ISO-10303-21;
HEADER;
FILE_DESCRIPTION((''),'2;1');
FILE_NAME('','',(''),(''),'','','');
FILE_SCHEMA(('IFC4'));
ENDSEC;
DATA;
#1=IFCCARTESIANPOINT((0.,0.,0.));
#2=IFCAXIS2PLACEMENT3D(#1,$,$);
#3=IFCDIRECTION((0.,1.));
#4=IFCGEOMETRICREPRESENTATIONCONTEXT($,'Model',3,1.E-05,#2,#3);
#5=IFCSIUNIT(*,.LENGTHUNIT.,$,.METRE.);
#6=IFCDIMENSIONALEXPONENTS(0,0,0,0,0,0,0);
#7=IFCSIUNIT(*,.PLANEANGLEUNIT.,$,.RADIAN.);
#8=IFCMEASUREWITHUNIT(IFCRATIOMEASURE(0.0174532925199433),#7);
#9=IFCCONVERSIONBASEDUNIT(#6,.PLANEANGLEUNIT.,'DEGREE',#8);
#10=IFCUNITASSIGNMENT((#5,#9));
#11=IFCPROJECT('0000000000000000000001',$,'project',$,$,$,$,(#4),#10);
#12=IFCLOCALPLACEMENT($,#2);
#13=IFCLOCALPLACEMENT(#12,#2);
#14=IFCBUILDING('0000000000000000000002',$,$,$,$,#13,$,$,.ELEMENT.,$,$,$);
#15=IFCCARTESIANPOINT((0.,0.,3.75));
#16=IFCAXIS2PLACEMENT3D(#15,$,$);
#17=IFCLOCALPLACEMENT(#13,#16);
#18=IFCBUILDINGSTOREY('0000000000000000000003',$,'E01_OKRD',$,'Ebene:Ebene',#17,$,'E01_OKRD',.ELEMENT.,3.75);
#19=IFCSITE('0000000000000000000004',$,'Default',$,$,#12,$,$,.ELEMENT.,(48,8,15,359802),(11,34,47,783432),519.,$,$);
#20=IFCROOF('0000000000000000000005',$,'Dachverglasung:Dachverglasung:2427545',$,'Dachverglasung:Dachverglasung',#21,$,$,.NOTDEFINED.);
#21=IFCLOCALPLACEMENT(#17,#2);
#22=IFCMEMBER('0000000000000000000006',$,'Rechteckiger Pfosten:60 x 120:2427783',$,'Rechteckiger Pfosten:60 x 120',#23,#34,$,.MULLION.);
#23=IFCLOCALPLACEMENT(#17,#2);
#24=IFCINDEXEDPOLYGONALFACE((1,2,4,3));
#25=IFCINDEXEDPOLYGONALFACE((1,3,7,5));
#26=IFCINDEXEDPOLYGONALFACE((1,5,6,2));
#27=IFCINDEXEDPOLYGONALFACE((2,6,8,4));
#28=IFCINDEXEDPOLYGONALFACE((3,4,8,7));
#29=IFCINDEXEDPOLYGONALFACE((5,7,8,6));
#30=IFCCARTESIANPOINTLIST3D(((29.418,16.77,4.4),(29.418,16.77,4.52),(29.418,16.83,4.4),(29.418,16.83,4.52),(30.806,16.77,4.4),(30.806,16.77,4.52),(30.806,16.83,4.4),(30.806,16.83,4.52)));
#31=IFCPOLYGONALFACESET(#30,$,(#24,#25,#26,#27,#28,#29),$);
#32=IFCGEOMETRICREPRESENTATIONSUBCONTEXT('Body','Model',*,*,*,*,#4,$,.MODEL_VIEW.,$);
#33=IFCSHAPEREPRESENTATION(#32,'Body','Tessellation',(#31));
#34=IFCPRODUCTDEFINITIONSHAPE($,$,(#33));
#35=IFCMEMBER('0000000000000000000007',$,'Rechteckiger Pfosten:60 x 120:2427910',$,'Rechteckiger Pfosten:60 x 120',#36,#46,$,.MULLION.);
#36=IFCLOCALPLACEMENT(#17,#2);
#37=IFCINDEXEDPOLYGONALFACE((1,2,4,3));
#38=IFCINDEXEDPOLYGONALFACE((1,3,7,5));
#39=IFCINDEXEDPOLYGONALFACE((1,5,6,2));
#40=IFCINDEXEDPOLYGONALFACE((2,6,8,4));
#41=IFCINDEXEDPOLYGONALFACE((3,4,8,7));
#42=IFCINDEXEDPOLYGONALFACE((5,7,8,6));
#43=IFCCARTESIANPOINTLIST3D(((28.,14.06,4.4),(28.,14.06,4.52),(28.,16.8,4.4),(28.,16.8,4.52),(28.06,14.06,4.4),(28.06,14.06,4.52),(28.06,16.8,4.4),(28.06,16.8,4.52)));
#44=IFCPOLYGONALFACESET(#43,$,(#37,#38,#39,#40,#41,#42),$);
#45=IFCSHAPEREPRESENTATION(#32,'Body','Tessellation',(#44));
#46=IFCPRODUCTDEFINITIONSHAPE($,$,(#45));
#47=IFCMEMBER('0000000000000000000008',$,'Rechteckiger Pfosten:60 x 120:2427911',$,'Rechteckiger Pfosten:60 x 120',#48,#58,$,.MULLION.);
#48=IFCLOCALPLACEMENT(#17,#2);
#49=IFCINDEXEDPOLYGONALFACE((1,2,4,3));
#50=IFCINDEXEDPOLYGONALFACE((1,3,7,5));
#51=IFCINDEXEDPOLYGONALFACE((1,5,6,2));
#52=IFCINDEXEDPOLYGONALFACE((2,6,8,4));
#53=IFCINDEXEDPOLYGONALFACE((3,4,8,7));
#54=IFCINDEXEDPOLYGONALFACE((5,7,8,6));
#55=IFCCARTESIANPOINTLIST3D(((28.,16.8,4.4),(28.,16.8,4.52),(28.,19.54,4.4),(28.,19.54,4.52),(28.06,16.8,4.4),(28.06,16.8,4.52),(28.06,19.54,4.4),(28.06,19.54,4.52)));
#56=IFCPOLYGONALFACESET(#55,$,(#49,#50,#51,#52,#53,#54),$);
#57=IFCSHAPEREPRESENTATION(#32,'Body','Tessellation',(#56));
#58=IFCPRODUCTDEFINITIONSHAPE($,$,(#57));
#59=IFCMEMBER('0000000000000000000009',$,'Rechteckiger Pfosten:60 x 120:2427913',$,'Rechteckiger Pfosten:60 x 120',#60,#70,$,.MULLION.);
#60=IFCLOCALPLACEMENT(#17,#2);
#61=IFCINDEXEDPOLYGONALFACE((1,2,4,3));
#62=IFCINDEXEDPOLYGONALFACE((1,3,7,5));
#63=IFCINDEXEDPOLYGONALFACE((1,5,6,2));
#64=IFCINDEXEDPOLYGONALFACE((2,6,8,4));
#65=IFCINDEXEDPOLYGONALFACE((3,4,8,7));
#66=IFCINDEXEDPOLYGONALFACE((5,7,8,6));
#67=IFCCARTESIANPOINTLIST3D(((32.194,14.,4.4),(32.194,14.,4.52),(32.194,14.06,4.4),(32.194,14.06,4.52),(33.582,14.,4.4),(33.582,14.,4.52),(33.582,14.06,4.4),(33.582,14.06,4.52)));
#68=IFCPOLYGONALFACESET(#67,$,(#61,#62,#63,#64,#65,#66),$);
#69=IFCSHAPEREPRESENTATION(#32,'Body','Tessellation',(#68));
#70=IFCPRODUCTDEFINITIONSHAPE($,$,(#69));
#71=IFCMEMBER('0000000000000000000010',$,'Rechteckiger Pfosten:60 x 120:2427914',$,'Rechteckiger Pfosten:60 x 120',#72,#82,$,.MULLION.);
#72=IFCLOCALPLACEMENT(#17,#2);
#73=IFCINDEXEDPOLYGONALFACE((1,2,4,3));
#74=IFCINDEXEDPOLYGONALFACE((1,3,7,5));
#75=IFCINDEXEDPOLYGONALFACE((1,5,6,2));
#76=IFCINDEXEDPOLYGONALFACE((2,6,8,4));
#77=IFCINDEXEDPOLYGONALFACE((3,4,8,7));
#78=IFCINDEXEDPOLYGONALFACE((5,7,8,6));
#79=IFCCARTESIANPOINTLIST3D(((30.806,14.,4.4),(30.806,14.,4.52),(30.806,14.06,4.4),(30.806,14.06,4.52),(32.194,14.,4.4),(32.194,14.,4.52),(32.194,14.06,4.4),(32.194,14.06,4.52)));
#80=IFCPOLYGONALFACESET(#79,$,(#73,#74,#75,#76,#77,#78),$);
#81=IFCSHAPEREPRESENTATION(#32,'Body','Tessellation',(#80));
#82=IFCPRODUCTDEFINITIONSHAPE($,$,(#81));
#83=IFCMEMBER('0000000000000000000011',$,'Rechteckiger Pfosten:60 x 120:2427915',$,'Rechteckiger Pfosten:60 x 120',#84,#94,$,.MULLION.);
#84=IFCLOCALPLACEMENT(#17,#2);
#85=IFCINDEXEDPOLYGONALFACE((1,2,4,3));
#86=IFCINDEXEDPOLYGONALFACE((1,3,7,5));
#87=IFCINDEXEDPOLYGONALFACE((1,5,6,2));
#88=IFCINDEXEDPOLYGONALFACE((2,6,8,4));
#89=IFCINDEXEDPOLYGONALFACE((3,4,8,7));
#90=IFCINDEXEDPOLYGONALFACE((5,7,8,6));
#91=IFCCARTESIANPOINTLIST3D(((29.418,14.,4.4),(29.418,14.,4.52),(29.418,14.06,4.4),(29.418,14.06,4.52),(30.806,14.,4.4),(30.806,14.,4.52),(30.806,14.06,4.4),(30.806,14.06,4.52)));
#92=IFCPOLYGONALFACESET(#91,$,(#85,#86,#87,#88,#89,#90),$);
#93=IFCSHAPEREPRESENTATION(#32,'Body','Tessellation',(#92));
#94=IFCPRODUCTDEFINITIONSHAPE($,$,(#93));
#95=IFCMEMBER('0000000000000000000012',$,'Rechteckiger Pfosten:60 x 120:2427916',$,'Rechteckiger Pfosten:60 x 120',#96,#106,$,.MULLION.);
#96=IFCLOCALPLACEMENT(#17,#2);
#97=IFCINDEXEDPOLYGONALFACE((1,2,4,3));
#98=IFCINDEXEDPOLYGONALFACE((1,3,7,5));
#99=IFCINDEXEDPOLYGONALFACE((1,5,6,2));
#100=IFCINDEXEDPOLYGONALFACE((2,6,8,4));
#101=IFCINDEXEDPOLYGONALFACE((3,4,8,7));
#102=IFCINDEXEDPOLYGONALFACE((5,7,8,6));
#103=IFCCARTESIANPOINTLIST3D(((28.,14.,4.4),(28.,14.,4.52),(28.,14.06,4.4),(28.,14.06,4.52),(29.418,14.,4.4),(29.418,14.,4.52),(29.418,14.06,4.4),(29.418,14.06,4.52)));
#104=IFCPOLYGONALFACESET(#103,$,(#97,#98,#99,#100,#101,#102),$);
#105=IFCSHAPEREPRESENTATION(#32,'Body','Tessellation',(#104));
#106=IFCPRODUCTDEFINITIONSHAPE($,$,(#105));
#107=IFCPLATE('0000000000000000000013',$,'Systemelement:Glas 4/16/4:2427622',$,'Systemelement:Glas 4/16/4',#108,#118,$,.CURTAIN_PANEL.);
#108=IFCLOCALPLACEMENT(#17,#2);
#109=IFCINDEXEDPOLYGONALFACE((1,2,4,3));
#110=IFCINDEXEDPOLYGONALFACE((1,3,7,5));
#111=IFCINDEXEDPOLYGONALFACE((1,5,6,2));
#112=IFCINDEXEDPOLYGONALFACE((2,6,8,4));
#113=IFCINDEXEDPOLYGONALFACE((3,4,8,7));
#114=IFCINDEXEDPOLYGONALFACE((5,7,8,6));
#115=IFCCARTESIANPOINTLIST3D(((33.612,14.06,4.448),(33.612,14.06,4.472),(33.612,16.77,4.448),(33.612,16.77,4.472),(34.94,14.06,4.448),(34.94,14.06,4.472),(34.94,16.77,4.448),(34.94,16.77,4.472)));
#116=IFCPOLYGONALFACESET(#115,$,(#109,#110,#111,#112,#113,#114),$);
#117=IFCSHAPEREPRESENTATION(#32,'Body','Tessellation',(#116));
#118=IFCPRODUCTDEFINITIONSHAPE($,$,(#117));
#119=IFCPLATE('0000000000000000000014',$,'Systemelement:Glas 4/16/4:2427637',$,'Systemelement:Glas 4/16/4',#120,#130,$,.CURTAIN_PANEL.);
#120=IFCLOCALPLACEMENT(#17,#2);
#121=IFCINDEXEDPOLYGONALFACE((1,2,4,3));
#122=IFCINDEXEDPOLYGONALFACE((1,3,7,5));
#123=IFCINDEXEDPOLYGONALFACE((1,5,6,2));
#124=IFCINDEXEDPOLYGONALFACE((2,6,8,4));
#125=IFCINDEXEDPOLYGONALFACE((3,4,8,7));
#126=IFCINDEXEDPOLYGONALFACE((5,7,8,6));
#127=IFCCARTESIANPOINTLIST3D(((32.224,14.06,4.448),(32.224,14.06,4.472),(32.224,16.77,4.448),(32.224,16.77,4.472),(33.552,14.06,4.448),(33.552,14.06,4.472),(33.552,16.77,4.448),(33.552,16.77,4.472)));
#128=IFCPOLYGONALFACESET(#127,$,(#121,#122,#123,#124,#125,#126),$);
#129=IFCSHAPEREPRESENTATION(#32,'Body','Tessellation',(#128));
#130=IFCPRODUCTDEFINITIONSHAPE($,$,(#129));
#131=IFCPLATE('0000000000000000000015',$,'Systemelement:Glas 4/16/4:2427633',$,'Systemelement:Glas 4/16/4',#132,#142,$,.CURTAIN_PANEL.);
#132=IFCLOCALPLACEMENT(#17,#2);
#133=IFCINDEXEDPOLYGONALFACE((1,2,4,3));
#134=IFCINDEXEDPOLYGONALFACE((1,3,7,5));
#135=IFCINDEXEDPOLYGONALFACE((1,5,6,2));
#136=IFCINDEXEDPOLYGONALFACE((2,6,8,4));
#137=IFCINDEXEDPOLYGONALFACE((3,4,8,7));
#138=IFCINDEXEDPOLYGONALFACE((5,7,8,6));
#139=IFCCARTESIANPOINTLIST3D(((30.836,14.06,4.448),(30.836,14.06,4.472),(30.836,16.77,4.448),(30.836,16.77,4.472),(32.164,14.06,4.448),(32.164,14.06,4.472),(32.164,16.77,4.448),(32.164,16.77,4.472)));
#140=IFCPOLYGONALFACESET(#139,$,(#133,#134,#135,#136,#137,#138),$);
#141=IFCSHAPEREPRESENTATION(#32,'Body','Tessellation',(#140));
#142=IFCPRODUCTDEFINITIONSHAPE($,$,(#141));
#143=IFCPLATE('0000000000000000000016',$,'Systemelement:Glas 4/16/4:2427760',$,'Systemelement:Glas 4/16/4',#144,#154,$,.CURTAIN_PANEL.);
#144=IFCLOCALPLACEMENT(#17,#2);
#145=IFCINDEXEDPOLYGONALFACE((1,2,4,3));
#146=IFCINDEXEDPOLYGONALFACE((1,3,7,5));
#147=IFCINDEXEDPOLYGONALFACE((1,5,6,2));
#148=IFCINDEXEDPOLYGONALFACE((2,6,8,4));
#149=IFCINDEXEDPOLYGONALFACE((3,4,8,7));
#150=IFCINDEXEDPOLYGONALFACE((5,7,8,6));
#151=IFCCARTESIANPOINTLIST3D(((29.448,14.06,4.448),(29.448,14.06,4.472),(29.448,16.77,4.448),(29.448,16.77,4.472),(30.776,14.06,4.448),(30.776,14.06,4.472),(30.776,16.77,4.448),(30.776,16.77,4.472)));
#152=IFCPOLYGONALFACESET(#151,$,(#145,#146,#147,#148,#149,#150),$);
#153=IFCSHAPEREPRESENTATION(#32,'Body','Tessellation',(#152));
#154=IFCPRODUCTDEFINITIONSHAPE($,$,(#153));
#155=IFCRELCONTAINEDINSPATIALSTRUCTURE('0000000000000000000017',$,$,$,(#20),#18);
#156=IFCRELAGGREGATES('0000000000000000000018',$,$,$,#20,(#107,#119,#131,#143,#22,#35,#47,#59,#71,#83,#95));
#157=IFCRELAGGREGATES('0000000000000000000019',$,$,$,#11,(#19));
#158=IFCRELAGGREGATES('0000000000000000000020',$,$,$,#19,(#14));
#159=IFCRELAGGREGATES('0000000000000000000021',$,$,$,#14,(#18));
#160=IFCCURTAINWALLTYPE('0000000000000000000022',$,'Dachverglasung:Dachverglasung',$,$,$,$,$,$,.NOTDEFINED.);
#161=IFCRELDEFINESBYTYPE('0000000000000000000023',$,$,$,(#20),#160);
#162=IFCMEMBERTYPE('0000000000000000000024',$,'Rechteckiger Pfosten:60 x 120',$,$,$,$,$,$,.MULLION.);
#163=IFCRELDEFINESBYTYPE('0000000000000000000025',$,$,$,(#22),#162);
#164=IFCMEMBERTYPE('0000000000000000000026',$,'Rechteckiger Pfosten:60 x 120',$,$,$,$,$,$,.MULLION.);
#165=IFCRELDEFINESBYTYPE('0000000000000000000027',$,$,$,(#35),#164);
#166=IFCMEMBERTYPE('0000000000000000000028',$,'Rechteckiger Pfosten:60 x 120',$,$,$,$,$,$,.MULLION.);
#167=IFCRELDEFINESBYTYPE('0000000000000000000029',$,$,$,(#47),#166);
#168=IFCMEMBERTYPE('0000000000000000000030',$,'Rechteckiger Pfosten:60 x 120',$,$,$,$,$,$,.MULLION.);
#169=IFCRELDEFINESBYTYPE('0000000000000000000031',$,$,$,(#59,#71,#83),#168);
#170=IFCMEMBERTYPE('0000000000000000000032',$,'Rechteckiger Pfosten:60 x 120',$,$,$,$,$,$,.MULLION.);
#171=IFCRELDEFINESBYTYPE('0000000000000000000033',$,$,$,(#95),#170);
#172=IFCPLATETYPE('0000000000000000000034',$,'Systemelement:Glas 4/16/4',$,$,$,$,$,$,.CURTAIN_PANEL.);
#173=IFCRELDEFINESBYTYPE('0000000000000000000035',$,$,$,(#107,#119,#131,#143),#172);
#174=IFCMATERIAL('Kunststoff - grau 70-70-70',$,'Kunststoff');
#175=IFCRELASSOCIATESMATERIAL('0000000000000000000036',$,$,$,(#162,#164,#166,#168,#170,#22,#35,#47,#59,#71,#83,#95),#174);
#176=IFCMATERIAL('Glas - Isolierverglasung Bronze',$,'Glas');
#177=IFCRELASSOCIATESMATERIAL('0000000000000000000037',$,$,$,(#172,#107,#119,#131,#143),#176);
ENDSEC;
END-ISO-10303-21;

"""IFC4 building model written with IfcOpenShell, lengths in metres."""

from ifc_helpers import new_model, entity, si_unit, converted_unit, direction, frame, frame_2d, origin, origin_2d_with_axis, place, context, subcontext, project, spatial, rectangle, extrude, shape, source, transform, mapped, material, material_profile, profile_set, profile_usage, type_object, type_shapes, element, aggregate, save


model = new_model("IFC4")

# Units and contexts
model_context = context("Model", 3, precision=1e-05, world=origin(), true_north=direction((0.0, 1.0)))
body_context = subcontext(model_context, "Body", "Model", "MODEL_VIEW")
footprint_context = subcontext(model_context, "FootPrint", "Model", "MODEL_VIEW")
ifc_project = project(units=[si_unit("LENGTHUNIT", "METRE"), converted_unit("PLANEANGLEUNIT", "DEGREE", entity("IfcRatioMeasure", 0.0174532925199433), si_unit("PLANEANGLEUNIT", "RADIAN"), dimensions=[0, 0, 0, 0, 0, 0, 0])], contexts=[model_context])

# Site, building, storey
site_placement = place(None, frame((0.0, 0.0, 0.0)))
site = spatial("IfcSite", under=ifc_project, at=site_placement, Name="Default", CompositionType="ELEMENT", RefLatitude=(48, 8, 15, 359802), RefLongitude=(11, 34, 47, 783432), RefElevation=519.0)
building_placement = place(site_placement, origin())
building = spatial("IfcBuilding", under=site, at=building_placement, CompositionType="ELEMENT")
storey_placement = place(building_placement, frame((0.0, 0.0, 3.75)))
storey = spatial("IfcBuildingStorey", under=building, at=storey_placement, Name="E01_OKRD", ObjectType="Ebene:Ebene", LongName="E01_OKRD", CompositionType="ELEMENT", Elevation=3.75)

# Roof, members, plates
curtain_wall_type = type_object("IfcCurtainWallType", Name="Dachverglasung:Dachverglasung", PredefinedType="NOTDEFINED")
roof_placement = place(storey_placement, frame((0.0, 0.0, -3.75)))
roof = element("IfcRoof", 1, at=roof_placement, inside=storey, type_object=curtain_wall_type, Name="Dachverglasung:Dachverglasung:2427545", ObjectType="Dachverglasung:Dachverglasung", PredefinedType="NOTDEFINED")
ifc_material_1 = material(Name="Kunststoff - grau 70-70-70", Category="Kunststoff")
ifc_material_profile_1 = material_profile(ifc_material_1, rectangle(XDim=0.06, YDim=0.12, at=frame_2d((0.0, 0.0), x_axis=(1.0, 0.0))), Name="60 x 120")
ifc_profile_set_1 = profile_set([ifc_material_profile_1], Name="60 x 120")
ifc_profile_usage_1 = profile_usage(ifc_profile_set_1)
member_type_1 = type_object("IfcMemberType", Name="Rechteckiger Pfosten:60 x 120", PredefinedType="MULLION", material=ifc_profile_set_1)
shared_shape_1 = source(origin(), body_context, "Body", "SweptSolid", [
    extrude(rectangle(XDim=0.06, YDim=0.12, at=frame_2d((0.0, 0.0), x_axis=(1.0, 0.0))), frame((0.0, 0.0, -1.388), z_axis=(0.0, 0.0, 1.0), x_axis=(-1.0, 0.0, 0.0)), (0.0, 0.0, 1.0), 1.388),
])
type_shapes(member_type_1, [shared_shape_1])
member_1_placement = place(storey_placement, frame((29.418, 16.8, 4.46), z_axis=(-1.0, 0.0, 0.0), x_axis=(0.0, 1.0, 0.0)))
member_1 = element("IfcMember", 2, at=member_1_placement, type_object=member_type_1, material=ifc_profile_usage_1, Name="Rechteckiger Pfosten:60 x 120:2427783", ObjectType="Rechteckiger Pfosten:60 x 120", PredefinedType="MULLION", context=body_context, shape_type="MappedRepresentation", body=[
    mapped(shared_shape_1, transform((0.0, 0.0, 0.0), scale=1.0)),
])
ifc_profile_usage_2 = profile_usage(ifc_profile_set_1)
member_type_2 = type_object("IfcMemberType", Name="Rechteckiger Pfosten:60 x 120", PredefinedType="MULLION", material=ifc_profile_set_1)
shared_shape_2 = source(origin(), body_context, "Body", "SweptSolid", [
    extrude(rectangle(XDim=0.06, YDim=0.12, at=origin_2d_with_axis()), frame((-0.03, 0.0, -2.74), z_axis=(0.0, 0.0, 1.0), x_axis=(-1.0, 0.0, 0.0)), (0.0, 0.0, 1.0), 2.74),
])
type_shapes(member_type_2, [shared_shape_2])
member_2_placement = place(storey_placement, frame((28.0, 14.06, 4.46), z_axis=(0.0, -1.0, 0.0), x_axis=(-1.0, 0.0, 0.0)))
member_2 = element("IfcMember", 3, at=member_2_placement, type_object=member_type_2, material=ifc_profile_usage_2, Name="Rechteckiger Pfosten:60 x 120:2427910", ObjectType="Rechteckiger Pfosten:60 x 120", PredefinedType="MULLION", context=body_context, shape_type="MappedRepresentation", body=[
    mapped(shared_shape_2, transform((0.0, 0.0, 0.0), scale=1.0)),
])
ifc_profile_usage_3 = profile_usage(ifc_profile_set_1)
member_type_3 = type_object("IfcMemberType", Name="Rechteckiger Pfosten:60 x 120", PredefinedType="MULLION", material=ifc_profile_set_1)
shared_shape_3 = source(origin(), body_context, "Body", "SweptSolid", [
    extrude(rectangle(XDim=0.06, YDim=0.12, at=origin_2d_with_axis()), frame((-0.03, 0.0, -2.74), z_axis=(0.0, 0.0, 1.0), x_axis=(-1.0, 0.0, 0.0)), (0.0, 0.0, 1.0), 2.74),
])
type_shapes(member_type_3, [shared_shape_3])
member_3_placement = place(storey_placement, frame((28.0, 16.8, 4.46), z_axis=(0.0, -1.0, 0.0), x_axis=(-1.0, 0.0, 0.0)))
member_3 = element("IfcMember", 4, at=member_3_placement, type_object=member_type_3, material=ifc_profile_usage_3, Name="Rechteckiger Pfosten:60 x 120:2427911", ObjectType="Rechteckiger Pfosten:60 x 120", PredefinedType="MULLION", context=body_context, shape_type="MappedRepresentation", body=[
    mapped(shared_shape_3, transform((0.0, 0.0, 0.0), scale=1.0)),
])
ifc_profile_usage_4 = profile_usage(ifc_profile_set_1)
member_type_4 = type_object("IfcMemberType", Name="Rechteckiger Pfosten:60 x 120", PredefinedType="MULLION", material=ifc_profile_set_1)
shared_shape_4 = source(origin(), body_context, "Body", "SweptSolid", [
    extrude(rectangle(XDim=0.06, YDim=0.12, at=origin_2d_with_axis()), frame((-0.03, 0.0, -1.388), z_axis=(0.0, 0.0, 1.0), x_axis=(-1.0, 0.0, 0.0)), (0.0, 0.0, 1.0), 1.388),
])
type_shapes(member_type_4, [shared_shape_4])
member_4_placement = place(storey_placement, frame((33.582, 14.0, 4.46), z_axis=(1.0, 0.0, 0.0), x_axis=(0.0, -1.0, 0.0)))
member_4 = element("IfcMember", 5, at=member_4_placement, type_object=member_type_4, material=ifc_profile_usage_4, Name="Rechteckiger Pfosten:60 x 120:2427913", ObjectType="Rechteckiger Pfosten:60 x 120", PredefinedType="MULLION", context=body_context, shape_type="MappedRepresentation", body=[
    mapped(shared_shape_4, transform((0.0, 0.0, 0.0), scale=1.0)),
])
ifc_profile_usage_5 = profile_usage(ifc_profile_set_1)
member_5_placement = place(storey_placement, frame((32.194, 14.0, 4.46), z_axis=(1.0, 0.0, 0.0), x_axis=(0.0, -1.0, 0.0)))
member_5 = element("IfcMember", 6, at=member_5_placement, type_object=member_type_4, material=ifc_profile_usage_5, Name="Rechteckiger Pfosten:60 x 120:2427914", ObjectType="Rechteckiger Pfosten:60 x 120", PredefinedType="MULLION", context=body_context, shape_type="MappedRepresentation", body=[
    mapped(shared_shape_4, transform((0.0, 0.0, 0.0), scale=1.0)),
])
ifc_profile_usage_6 = profile_usage(ifc_profile_set_1)
member_6_placement = place(storey_placement, frame((30.806, 14.0, 4.46), z_axis=(1.0, 0.0, 0.0), x_axis=(0.0, -1.0, 0.0)))
member_6 = element("IfcMember", 7, at=member_6_placement, type_object=member_type_4, material=ifc_profile_usage_6, Name="Rechteckiger Pfosten:60 x 120:2427915", ObjectType="Rechteckiger Pfosten:60 x 120", PredefinedType="MULLION", context=body_context, shape_type="MappedRepresentation", body=[
    mapped(shared_shape_4, transform((0.0, 0.0, 0.0), scale=1.0)),
])
ifc_profile_usage_7 = profile_usage(ifc_profile_set_1)
member_type_5 = type_object("IfcMemberType", Name="Rechteckiger Pfosten:60 x 120", PredefinedType="MULLION", material=ifc_profile_set_1)
shared_shape_5 = source(origin(), body_context, "Body", "SweptSolid", [
    extrude(rectangle(XDim=0.06, YDim=0.12, at=origin_2d_with_axis()), frame((-0.03, 0.0, -1.418), z_axis=(0.0, 0.0, 1.0), x_axis=(-1.0, 0.0, 0.0)), (0.0, 0.0, 1.0), 1.418),
])
type_shapes(member_type_5, [shared_shape_5])
member_7_placement = place(storey_placement, frame((29.418, 14.0, 4.46), z_axis=(1.0, 0.0, 0.0), x_axis=(0.0, -1.0, 0.0)))
member_7 = element("IfcMember", 8, at=member_7_placement, type_object=member_type_5, material=ifc_profile_usage_7, Name="Rechteckiger Pfosten:60 x 120:2427916", ObjectType="Rechteckiger Pfosten:60 x 120", PredefinedType="MULLION", context=body_context, shape_type="MappedRepresentation", body=[
    mapped(shared_shape_5, transform((0.0, 0.0, 0.0), scale=1.0)),
])
ifc_material_2 = material(Name="Glas - Isolierverglasung Bronze", Category="Glas")
plate_type = type_object("IfcPlateType", Name="Systemelement:Glas 4/16/4", PredefinedType="CURTAIN_PANEL", material=ifc_material_2)
shared_shape_6 = source(origin(), body_context, "Body", "SweptSolid", [
    extrude(rectangle(XDim=0.024, YDim=2.71, at=origin_2d_with_axis()), frame((0.0, 0.0, 0.0), z_axis=(0.0, 0.0, 1.0), x_axis=(0.0, 1.0, 0.0)), (0.0, 0.0, 1.0), 1.328),
])
cartesian_point = entity("IfcCartesianPoint", [1.355, -0.012])
shared_shape_7 = source(origin(), footprint_context, "FootPrint", "Curve2D", [
    entity("IfcPolyline", [cartesian_point, entity("IfcCartesianPoint", [1.355, 0.012]), entity("IfcCartesianPoint", [-1.355, 0.012]), entity("IfcCartesianPoint", [-1.355, -0.012]), cartesian_point]),
])
type_shapes(plate_type, [shared_shape_6, shared_shape_7])
plate_1_placement = place(roof_placement, frame((34.94, 15.415, 8.21), z_axis=(-1.0, 0.0, 0.0), x_axis=(0.0, 1.0, 0.0)))
plate_1 = element("IfcPlate", 9, at=plate_1_placement, type_object=plate_type, material=ifc_material_2, Name="Systemelement:Glas 4/16/4:2427622", ObjectType="Systemelement:Glas 4/16/4", PredefinedType="CURTAIN_PANEL", shapes=[
    shape(body_context, "Body", "MappedRepresentation", [mapped(shared_shape_6, transform((0.0, 0.0, 0.0), scale=1.0))]),
    shape(body_context, "Body", "MappedRepresentation", [mapped(shared_shape_7, transform((0.0, 0.0, 0.0), scale=1.0))]),
])
plate_2_placement = place(roof_placement, frame((33.552, 15.415, 8.21), z_axis=(-1.0, 0.0, 0.0), x_axis=(0.0, 1.0, 0.0)))
plate_2 = element("IfcPlate", 10, at=plate_2_placement, type_object=plate_type, material=ifc_material_2, Name="Systemelement:Glas 4/16/4:2427637", ObjectType="Systemelement:Glas 4/16/4", PredefinedType="CURTAIN_PANEL", shapes=[
    shape(body_context, "Body", "MappedRepresentation", [mapped(shared_shape_6, transform((0.0, 0.0, 0.0), scale=1.0))]),
    shape(body_context, "Body", "MappedRepresentation", [mapped(shared_shape_7, transform((0.0, 0.0, 0.0), scale=1.0))]),
])
plate_3_placement = place(roof_placement, frame((32.164, 15.415, 8.21), z_axis=(-1.0, 0.0, 0.0), x_axis=(0.0, 1.0, 0.0)))
plate_3 = element("IfcPlate", 11, at=plate_3_placement, type_object=plate_type, material=ifc_material_2, Name="Systemelement:Glas 4/16/4:2427633", ObjectType="Systemelement:Glas 4/16/4", PredefinedType="CURTAIN_PANEL", shapes=[
    shape(body_context, "Body", "MappedRepresentation", [mapped(shared_shape_6, transform((0.0, 0.0, 0.0), scale=1.0))]),
    shape(body_context, "Body", "MappedRepresentation", [mapped(shared_shape_7, transform((0.0, 0.0, 0.0), scale=1.0))]),
])
plate_4_placement = place(roof_placement, frame((30.776, 15.415, 8.21), z_axis=(-1.0, 0.0, 0.0), x_axis=(0.0, 1.0, 0.0)))
plate_4 = element("IfcPlate", 12, at=plate_4_placement, type_object=plate_type, material=ifc_material_2, Name="Systemelement:Glas 4/16/4:2427760", ObjectType="Systemelement:Glas 4/16/4", PredefinedType="CURTAIN_PANEL", shapes=[
    shape(body_context, "Body", "MappedRepresentation", [mapped(shared_shape_6, transform((0.0, 0.0, 0.0), scale=1.0))]),
    shape(body_context, "Body", "MappedRepresentation", [mapped(shared_shape_7, transform((0.0, 0.0, 0.0), scale=1.0))]),
])
aggregate(roof, [plate_1, plate_2, plate_3, plate_4, member_1, member_2, member_3, member_4, member_5, member_6, member_7])

save(model, "model.ifc")
